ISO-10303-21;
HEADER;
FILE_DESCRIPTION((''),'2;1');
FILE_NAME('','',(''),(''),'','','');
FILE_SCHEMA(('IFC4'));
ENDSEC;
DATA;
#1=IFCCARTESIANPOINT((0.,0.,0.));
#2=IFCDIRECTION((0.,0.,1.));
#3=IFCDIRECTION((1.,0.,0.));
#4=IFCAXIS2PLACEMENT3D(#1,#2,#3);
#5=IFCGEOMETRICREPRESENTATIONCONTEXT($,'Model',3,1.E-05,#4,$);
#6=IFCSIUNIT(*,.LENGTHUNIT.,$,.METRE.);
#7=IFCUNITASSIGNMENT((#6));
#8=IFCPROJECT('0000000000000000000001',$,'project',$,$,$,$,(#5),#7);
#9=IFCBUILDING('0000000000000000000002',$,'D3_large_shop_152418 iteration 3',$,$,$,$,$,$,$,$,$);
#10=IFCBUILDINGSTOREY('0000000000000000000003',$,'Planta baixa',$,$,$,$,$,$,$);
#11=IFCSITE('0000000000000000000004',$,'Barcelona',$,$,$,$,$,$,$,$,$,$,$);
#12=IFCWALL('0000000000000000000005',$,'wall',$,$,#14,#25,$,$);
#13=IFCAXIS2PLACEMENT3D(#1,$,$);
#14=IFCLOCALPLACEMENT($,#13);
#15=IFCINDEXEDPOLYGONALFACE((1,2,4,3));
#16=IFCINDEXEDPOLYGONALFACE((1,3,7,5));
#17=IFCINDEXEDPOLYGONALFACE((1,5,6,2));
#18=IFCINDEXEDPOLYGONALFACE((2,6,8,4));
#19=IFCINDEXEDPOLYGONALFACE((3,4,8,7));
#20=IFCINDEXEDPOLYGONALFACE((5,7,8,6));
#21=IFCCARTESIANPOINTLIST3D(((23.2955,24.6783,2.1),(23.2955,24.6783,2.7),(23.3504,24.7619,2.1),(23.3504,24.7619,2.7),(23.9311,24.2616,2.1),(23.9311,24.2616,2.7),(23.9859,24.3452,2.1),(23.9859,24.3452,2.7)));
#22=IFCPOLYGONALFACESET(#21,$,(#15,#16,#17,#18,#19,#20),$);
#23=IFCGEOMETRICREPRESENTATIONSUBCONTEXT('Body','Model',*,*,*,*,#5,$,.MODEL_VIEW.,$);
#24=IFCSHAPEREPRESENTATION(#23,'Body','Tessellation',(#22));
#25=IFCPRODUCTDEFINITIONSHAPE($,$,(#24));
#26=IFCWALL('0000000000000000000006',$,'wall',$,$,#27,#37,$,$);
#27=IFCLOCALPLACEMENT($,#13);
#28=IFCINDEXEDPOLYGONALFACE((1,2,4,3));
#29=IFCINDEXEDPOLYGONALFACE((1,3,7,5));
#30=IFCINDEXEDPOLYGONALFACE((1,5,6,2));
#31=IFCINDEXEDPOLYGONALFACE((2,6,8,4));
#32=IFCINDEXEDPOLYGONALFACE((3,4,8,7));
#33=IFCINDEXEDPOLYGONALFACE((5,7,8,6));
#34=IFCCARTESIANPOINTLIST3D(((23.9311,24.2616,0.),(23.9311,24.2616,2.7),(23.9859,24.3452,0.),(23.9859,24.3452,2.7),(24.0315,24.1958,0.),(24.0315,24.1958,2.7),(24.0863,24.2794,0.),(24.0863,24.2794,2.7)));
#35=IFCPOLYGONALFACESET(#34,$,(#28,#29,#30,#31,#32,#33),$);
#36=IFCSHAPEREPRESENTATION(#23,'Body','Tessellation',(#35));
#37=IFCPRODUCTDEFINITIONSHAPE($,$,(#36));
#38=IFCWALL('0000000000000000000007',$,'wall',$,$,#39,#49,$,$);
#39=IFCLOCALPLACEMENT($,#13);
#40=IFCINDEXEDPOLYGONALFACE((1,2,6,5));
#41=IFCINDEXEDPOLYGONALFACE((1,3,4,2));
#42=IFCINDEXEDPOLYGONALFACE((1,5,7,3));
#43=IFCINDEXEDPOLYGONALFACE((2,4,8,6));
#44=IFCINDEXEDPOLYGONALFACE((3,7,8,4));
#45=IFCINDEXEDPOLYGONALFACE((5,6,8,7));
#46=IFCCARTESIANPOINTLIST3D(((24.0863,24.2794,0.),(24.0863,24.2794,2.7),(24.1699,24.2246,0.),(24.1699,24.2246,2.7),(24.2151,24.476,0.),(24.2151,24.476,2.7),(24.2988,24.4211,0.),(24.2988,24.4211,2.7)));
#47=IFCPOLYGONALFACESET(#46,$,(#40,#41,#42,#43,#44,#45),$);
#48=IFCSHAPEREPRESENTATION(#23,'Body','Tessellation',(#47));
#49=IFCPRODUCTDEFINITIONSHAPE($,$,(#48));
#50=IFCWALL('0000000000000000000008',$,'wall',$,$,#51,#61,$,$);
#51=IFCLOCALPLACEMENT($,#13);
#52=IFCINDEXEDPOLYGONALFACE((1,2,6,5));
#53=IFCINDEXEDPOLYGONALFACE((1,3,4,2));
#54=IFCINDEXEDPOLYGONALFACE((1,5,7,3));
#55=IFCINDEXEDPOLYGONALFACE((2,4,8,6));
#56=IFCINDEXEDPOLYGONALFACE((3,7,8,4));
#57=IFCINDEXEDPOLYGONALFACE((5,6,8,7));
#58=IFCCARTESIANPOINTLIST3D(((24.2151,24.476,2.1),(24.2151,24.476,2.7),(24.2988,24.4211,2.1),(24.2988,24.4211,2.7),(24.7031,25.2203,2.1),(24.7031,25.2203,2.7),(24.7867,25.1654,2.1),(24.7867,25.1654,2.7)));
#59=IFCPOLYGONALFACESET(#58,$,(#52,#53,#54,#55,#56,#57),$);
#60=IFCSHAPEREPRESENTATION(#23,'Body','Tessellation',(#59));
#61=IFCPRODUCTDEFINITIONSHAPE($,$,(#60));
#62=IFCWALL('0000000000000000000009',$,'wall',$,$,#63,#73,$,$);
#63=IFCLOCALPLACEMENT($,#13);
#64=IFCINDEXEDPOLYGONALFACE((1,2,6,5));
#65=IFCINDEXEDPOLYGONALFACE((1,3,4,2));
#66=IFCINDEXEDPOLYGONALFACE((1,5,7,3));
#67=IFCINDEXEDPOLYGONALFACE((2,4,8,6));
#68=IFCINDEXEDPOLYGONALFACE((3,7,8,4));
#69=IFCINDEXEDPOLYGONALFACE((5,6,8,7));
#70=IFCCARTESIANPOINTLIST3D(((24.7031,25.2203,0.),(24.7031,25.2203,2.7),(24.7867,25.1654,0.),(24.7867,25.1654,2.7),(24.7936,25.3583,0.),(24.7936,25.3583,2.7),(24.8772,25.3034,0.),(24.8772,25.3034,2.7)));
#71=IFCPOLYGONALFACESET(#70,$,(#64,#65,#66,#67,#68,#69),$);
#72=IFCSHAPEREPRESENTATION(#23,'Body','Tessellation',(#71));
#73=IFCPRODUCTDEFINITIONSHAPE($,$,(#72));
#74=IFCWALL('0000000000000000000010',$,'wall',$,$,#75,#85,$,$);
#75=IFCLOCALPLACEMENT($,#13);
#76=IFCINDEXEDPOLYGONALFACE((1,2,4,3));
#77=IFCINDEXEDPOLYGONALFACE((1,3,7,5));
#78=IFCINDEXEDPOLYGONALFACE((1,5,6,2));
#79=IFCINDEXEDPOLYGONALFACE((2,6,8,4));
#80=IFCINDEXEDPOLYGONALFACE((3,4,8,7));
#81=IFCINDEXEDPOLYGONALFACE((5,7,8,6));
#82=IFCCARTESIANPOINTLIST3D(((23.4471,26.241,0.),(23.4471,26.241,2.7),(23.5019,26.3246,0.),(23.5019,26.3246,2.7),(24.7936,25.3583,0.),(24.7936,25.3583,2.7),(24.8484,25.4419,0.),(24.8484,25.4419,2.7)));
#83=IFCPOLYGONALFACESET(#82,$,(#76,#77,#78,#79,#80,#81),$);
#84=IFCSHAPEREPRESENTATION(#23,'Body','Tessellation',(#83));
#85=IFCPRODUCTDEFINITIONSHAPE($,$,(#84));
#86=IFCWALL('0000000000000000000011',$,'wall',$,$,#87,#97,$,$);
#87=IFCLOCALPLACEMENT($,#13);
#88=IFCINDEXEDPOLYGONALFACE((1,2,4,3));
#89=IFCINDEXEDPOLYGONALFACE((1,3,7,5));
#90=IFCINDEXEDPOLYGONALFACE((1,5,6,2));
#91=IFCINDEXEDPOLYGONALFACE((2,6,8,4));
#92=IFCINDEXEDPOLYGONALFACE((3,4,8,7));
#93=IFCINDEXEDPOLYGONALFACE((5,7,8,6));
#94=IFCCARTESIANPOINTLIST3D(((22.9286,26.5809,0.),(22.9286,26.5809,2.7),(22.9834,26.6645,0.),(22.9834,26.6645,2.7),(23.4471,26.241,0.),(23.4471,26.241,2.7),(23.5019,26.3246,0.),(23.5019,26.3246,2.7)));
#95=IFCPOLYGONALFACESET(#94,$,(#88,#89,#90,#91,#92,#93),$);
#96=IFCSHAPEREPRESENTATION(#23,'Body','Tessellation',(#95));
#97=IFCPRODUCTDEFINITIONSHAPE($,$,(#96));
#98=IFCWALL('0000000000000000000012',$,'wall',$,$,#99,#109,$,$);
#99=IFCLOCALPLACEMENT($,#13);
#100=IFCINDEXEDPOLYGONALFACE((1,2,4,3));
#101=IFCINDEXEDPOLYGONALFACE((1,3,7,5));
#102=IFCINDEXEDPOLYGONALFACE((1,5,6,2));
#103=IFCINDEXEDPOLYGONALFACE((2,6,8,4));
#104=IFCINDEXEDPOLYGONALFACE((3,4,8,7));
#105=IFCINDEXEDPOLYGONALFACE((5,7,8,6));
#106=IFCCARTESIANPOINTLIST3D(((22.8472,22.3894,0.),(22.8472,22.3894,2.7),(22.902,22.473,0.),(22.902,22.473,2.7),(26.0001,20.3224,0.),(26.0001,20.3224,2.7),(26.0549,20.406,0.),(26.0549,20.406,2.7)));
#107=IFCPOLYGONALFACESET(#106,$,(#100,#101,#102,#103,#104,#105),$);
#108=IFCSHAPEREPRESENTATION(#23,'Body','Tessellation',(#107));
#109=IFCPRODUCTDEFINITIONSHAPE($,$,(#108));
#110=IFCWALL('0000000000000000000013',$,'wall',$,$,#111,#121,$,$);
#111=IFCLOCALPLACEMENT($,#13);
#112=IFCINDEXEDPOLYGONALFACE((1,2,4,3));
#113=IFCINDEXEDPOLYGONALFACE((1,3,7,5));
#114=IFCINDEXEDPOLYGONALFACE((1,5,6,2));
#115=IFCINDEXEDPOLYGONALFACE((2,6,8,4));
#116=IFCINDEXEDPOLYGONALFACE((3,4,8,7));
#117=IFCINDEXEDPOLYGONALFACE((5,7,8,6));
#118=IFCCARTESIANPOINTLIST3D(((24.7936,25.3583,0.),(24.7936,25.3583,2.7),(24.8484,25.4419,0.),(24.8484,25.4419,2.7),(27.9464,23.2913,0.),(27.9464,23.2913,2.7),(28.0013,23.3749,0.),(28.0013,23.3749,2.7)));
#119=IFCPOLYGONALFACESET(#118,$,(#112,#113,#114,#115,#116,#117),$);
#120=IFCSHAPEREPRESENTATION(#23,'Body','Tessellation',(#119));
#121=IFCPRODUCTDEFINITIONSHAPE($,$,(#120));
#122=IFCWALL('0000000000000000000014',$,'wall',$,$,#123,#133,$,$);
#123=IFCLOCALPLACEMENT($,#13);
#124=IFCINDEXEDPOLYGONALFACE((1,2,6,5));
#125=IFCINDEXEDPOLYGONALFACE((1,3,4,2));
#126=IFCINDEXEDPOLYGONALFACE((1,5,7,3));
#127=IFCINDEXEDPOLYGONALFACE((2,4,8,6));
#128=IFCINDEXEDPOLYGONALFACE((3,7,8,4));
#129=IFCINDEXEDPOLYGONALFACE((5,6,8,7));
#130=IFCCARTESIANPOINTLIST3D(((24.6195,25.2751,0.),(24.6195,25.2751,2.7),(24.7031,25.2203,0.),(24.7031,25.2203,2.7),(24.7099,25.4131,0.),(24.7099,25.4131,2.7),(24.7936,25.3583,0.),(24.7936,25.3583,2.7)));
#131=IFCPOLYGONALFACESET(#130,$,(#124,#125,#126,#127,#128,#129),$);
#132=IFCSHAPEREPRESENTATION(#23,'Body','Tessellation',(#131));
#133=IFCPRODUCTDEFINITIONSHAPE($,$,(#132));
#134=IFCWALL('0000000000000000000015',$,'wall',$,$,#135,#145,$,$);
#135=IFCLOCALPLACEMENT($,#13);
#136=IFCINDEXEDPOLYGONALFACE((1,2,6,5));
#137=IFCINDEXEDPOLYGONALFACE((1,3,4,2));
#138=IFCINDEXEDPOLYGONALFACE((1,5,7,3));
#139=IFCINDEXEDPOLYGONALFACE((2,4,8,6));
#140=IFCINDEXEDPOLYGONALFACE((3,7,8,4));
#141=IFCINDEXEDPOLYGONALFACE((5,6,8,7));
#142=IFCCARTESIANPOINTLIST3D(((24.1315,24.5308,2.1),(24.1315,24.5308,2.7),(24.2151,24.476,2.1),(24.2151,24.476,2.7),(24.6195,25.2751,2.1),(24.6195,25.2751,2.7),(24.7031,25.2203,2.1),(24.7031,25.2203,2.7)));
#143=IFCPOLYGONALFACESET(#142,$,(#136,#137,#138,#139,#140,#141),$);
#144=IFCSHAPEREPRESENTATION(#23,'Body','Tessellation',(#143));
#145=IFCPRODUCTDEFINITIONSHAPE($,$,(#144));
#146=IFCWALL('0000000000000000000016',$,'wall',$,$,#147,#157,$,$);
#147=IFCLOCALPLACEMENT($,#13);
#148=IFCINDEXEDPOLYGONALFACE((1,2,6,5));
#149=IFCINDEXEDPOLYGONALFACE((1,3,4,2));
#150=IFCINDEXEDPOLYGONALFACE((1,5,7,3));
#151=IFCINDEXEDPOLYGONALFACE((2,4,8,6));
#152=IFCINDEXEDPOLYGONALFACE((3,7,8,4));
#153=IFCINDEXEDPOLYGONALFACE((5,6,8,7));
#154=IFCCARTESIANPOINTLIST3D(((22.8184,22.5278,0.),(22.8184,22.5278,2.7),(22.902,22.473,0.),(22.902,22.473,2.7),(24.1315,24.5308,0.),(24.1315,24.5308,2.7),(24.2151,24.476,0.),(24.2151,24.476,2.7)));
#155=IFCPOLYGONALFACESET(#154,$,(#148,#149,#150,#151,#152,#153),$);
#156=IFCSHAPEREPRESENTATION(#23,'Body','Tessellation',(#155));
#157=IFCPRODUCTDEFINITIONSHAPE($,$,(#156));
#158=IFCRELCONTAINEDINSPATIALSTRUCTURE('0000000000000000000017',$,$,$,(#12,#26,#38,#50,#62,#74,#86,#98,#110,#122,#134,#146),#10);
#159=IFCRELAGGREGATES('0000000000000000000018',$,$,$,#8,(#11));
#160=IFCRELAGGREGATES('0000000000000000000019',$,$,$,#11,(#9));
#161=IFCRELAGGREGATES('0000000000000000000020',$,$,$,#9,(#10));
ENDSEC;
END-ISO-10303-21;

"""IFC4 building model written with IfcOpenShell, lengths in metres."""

from ifc_helpers import new_model, si_unit, frame, origin, origin_with_axes, place, context, subcontext, project, spatial, polyline, outline, extrude, element, save


model = new_model("IFC4")

# Units and contexts
model_context = context("Model", 3, precision=1e-05, world=origin_with_axes())
body_context = subcontext(model_context, "Body", "Model", "MODEL_VIEW")
ifc_project = project(units=[si_unit("LENGTHUNIT", "METRE")], contexts=[model_context])

# Site, building, storey
site = spatial("IfcSite", under=ifc_project, Name="Barcelona")
building = spatial("IfcBuilding", under=site, Name="D3_large_shop_152418 iteration 3")
storey = spatial("IfcBuildingStorey", under=building, Name="Planta baixa")

# Walls
wall_1_placement = place(None, origin_with_axes())
element("IfcWall", 1, at=wall_1_placement, inside=storey, Name="wall", context=body_context, shape_type="SweptSolid", body=[
    extrude(outline(polyline([(23.3504, 24.7619), (23.9859, 24.3452), (23.9311, 24.2616), (23.2955, 24.6783), (23.3504, 24.7619)])), frame((0.0, 0.0, 2.1)), (0.0, 0.0, 1.0), 0.6),
])
wall_2_placement = place(None, origin_with_axes())
element("IfcWall", 2, at=wall_2_placement, inside=storey, Name="wall", context=body_context, shape_type="SweptSolid", body=[
    extrude(outline(polyline([(23.9859, 24.3452), (24.0863, 24.2794), (24.0315, 24.1958), (23.9311, 24.2616), (23.9859, 24.3452)])), origin(), (0.0, 0.0, 1.0), 2.7),
])
wall_3_placement = place(None, origin_with_axes())
element("IfcWall", 3, at=wall_3_placement, inside=storey, Name="wall", context=body_context, shape_type="SweptSolid", body=[
    extrude(outline(polyline([(24.0863, 24.2794), (24.2151, 24.476), (24.2988, 24.4211), (24.1699, 24.2246), (24.0863, 24.2794)])), origin(), (0.0, 0.0, 1.0), 2.7),
])
wall_4_placement = place(None, origin_with_axes())
element("IfcWall", 4, at=wall_4_placement, inside=storey, Name="wall", context=body_context, shape_type="SweptSolid", body=[
    extrude(outline(polyline([(24.2151, 24.476), (24.7031, 25.2203), (24.7867, 25.1654), (24.2988, 24.4211), (24.2151, 24.476)])), frame((0.0, 0.0, 2.1)), (0.0, 0.0, 1.0), 0.6),
])
wall_5_placement = place(None, origin_with_axes())
element("IfcWall", 5, at=wall_5_placement, inside=storey, Name="wall", context=body_context, shape_type="SweptSolid", body=[
    extrude(outline(polyline([(24.7031, 25.2203), (24.7936, 25.3583), (24.8772, 25.3034), (24.7867, 25.1654), (24.7031, 25.2203)])), origin(), (0.0, 0.0, 1.0), 2.7),
])
wall_6_placement = place(None, origin_with_axes())
element("IfcWall", 6, at=wall_6_placement, inside=storey, Name="wall", context=body_context, shape_type="SweptSolid", body=[
    extrude(outline(polyline([(24.7936, 25.3583), (23.4471, 26.241), (23.5019, 26.3246), (24.8484, 25.4419), (24.7936, 25.3583)])), origin(), (0.0, 0.0, 1.0), 2.7),
])
wall_7_placement = place(None, origin_with_axes())
element("IfcWall", 7, at=wall_7_placement, inside=storey, Name="wall", context=body_context, shape_type="SweptSolid", body=[
    extrude(outline(polyline([(23.4471, 26.241), (22.9286, 26.5809), (22.9834, 26.6645), (23.5019, 26.3246), (23.4471, 26.241)])), origin(), (0.0, 0.0, 1.0), 2.7),
])
wall_8_placement = place(None, origin_with_axes())
element("IfcWall", 8, at=wall_8_placement, inside=storey, Name="wall", context=body_context, shape_type="SweptSolid", body=[
    extrude(outline(polyline([(22.902, 22.473), (26.0549, 20.406), (26.0001, 20.3224), (22.8472, 22.3894), (22.902, 22.473)])), origin(), (0.0, 0.0, 1.0), 2.7),
])
wall_9_placement = place(None, origin_with_axes())
element("IfcWall", 9, at=wall_9_placement, inside=storey, Name="wall", context=body_context, shape_type="SweptSolid", body=[
    extrude(outline(polyline([(27.9464, 23.2913), (24.7936, 25.3583), (24.8484, 25.4419), (28.0013, 23.3749), (27.9464, 23.2913)])), origin(), (0.0, 0.0, 1.0), 2.7),
])
wall_10_placement = place(None, origin_with_axes())
element("IfcWall", 10, at=wall_10_placement, inside=storey, Name="wall", context=body_context, shape_type="SweptSolid", body=[
    extrude(outline(polyline([(24.7936, 25.3583), (24.7031, 25.2203), (24.6195, 25.2751), (24.7099, 25.4131), (24.7936, 25.3583)])), origin(), (0.0, 0.0, 1.0), 2.7),
])
wall_11_placement = place(None, origin_with_axes())
element("IfcWall", 11, at=wall_11_placement, inside=storey, Name="wall", context=body_context, shape_type="SweptSolid", body=[
    extrude(outline(polyline([(24.7031, 25.2203), (24.2151, 24.476), (24.1315, 24.5308), (24.6195, 25.2751), (24.7031, 25.2203)])), frame((0.0, 0.0, 2.1)), (0.0, 0.0, 1.0), 0.6),
])
wall_12_placement = place(None, origin_with_axes())
element("IfcWall", 12, at=wall_12_placement, inside=storey, Name="wall", context=body_context, shape_type="SweptSolid", body=[
    extrude(outline(polyline([(24.2151, 24.476), (22.902, 22.473), (22.8184, 22.5278), (24.1315, 24.5308), (24.2151, 24.476)])), origin(), (0.0, 0.0, 1.0), 2.7),
])

save(model, "model.ifc")
